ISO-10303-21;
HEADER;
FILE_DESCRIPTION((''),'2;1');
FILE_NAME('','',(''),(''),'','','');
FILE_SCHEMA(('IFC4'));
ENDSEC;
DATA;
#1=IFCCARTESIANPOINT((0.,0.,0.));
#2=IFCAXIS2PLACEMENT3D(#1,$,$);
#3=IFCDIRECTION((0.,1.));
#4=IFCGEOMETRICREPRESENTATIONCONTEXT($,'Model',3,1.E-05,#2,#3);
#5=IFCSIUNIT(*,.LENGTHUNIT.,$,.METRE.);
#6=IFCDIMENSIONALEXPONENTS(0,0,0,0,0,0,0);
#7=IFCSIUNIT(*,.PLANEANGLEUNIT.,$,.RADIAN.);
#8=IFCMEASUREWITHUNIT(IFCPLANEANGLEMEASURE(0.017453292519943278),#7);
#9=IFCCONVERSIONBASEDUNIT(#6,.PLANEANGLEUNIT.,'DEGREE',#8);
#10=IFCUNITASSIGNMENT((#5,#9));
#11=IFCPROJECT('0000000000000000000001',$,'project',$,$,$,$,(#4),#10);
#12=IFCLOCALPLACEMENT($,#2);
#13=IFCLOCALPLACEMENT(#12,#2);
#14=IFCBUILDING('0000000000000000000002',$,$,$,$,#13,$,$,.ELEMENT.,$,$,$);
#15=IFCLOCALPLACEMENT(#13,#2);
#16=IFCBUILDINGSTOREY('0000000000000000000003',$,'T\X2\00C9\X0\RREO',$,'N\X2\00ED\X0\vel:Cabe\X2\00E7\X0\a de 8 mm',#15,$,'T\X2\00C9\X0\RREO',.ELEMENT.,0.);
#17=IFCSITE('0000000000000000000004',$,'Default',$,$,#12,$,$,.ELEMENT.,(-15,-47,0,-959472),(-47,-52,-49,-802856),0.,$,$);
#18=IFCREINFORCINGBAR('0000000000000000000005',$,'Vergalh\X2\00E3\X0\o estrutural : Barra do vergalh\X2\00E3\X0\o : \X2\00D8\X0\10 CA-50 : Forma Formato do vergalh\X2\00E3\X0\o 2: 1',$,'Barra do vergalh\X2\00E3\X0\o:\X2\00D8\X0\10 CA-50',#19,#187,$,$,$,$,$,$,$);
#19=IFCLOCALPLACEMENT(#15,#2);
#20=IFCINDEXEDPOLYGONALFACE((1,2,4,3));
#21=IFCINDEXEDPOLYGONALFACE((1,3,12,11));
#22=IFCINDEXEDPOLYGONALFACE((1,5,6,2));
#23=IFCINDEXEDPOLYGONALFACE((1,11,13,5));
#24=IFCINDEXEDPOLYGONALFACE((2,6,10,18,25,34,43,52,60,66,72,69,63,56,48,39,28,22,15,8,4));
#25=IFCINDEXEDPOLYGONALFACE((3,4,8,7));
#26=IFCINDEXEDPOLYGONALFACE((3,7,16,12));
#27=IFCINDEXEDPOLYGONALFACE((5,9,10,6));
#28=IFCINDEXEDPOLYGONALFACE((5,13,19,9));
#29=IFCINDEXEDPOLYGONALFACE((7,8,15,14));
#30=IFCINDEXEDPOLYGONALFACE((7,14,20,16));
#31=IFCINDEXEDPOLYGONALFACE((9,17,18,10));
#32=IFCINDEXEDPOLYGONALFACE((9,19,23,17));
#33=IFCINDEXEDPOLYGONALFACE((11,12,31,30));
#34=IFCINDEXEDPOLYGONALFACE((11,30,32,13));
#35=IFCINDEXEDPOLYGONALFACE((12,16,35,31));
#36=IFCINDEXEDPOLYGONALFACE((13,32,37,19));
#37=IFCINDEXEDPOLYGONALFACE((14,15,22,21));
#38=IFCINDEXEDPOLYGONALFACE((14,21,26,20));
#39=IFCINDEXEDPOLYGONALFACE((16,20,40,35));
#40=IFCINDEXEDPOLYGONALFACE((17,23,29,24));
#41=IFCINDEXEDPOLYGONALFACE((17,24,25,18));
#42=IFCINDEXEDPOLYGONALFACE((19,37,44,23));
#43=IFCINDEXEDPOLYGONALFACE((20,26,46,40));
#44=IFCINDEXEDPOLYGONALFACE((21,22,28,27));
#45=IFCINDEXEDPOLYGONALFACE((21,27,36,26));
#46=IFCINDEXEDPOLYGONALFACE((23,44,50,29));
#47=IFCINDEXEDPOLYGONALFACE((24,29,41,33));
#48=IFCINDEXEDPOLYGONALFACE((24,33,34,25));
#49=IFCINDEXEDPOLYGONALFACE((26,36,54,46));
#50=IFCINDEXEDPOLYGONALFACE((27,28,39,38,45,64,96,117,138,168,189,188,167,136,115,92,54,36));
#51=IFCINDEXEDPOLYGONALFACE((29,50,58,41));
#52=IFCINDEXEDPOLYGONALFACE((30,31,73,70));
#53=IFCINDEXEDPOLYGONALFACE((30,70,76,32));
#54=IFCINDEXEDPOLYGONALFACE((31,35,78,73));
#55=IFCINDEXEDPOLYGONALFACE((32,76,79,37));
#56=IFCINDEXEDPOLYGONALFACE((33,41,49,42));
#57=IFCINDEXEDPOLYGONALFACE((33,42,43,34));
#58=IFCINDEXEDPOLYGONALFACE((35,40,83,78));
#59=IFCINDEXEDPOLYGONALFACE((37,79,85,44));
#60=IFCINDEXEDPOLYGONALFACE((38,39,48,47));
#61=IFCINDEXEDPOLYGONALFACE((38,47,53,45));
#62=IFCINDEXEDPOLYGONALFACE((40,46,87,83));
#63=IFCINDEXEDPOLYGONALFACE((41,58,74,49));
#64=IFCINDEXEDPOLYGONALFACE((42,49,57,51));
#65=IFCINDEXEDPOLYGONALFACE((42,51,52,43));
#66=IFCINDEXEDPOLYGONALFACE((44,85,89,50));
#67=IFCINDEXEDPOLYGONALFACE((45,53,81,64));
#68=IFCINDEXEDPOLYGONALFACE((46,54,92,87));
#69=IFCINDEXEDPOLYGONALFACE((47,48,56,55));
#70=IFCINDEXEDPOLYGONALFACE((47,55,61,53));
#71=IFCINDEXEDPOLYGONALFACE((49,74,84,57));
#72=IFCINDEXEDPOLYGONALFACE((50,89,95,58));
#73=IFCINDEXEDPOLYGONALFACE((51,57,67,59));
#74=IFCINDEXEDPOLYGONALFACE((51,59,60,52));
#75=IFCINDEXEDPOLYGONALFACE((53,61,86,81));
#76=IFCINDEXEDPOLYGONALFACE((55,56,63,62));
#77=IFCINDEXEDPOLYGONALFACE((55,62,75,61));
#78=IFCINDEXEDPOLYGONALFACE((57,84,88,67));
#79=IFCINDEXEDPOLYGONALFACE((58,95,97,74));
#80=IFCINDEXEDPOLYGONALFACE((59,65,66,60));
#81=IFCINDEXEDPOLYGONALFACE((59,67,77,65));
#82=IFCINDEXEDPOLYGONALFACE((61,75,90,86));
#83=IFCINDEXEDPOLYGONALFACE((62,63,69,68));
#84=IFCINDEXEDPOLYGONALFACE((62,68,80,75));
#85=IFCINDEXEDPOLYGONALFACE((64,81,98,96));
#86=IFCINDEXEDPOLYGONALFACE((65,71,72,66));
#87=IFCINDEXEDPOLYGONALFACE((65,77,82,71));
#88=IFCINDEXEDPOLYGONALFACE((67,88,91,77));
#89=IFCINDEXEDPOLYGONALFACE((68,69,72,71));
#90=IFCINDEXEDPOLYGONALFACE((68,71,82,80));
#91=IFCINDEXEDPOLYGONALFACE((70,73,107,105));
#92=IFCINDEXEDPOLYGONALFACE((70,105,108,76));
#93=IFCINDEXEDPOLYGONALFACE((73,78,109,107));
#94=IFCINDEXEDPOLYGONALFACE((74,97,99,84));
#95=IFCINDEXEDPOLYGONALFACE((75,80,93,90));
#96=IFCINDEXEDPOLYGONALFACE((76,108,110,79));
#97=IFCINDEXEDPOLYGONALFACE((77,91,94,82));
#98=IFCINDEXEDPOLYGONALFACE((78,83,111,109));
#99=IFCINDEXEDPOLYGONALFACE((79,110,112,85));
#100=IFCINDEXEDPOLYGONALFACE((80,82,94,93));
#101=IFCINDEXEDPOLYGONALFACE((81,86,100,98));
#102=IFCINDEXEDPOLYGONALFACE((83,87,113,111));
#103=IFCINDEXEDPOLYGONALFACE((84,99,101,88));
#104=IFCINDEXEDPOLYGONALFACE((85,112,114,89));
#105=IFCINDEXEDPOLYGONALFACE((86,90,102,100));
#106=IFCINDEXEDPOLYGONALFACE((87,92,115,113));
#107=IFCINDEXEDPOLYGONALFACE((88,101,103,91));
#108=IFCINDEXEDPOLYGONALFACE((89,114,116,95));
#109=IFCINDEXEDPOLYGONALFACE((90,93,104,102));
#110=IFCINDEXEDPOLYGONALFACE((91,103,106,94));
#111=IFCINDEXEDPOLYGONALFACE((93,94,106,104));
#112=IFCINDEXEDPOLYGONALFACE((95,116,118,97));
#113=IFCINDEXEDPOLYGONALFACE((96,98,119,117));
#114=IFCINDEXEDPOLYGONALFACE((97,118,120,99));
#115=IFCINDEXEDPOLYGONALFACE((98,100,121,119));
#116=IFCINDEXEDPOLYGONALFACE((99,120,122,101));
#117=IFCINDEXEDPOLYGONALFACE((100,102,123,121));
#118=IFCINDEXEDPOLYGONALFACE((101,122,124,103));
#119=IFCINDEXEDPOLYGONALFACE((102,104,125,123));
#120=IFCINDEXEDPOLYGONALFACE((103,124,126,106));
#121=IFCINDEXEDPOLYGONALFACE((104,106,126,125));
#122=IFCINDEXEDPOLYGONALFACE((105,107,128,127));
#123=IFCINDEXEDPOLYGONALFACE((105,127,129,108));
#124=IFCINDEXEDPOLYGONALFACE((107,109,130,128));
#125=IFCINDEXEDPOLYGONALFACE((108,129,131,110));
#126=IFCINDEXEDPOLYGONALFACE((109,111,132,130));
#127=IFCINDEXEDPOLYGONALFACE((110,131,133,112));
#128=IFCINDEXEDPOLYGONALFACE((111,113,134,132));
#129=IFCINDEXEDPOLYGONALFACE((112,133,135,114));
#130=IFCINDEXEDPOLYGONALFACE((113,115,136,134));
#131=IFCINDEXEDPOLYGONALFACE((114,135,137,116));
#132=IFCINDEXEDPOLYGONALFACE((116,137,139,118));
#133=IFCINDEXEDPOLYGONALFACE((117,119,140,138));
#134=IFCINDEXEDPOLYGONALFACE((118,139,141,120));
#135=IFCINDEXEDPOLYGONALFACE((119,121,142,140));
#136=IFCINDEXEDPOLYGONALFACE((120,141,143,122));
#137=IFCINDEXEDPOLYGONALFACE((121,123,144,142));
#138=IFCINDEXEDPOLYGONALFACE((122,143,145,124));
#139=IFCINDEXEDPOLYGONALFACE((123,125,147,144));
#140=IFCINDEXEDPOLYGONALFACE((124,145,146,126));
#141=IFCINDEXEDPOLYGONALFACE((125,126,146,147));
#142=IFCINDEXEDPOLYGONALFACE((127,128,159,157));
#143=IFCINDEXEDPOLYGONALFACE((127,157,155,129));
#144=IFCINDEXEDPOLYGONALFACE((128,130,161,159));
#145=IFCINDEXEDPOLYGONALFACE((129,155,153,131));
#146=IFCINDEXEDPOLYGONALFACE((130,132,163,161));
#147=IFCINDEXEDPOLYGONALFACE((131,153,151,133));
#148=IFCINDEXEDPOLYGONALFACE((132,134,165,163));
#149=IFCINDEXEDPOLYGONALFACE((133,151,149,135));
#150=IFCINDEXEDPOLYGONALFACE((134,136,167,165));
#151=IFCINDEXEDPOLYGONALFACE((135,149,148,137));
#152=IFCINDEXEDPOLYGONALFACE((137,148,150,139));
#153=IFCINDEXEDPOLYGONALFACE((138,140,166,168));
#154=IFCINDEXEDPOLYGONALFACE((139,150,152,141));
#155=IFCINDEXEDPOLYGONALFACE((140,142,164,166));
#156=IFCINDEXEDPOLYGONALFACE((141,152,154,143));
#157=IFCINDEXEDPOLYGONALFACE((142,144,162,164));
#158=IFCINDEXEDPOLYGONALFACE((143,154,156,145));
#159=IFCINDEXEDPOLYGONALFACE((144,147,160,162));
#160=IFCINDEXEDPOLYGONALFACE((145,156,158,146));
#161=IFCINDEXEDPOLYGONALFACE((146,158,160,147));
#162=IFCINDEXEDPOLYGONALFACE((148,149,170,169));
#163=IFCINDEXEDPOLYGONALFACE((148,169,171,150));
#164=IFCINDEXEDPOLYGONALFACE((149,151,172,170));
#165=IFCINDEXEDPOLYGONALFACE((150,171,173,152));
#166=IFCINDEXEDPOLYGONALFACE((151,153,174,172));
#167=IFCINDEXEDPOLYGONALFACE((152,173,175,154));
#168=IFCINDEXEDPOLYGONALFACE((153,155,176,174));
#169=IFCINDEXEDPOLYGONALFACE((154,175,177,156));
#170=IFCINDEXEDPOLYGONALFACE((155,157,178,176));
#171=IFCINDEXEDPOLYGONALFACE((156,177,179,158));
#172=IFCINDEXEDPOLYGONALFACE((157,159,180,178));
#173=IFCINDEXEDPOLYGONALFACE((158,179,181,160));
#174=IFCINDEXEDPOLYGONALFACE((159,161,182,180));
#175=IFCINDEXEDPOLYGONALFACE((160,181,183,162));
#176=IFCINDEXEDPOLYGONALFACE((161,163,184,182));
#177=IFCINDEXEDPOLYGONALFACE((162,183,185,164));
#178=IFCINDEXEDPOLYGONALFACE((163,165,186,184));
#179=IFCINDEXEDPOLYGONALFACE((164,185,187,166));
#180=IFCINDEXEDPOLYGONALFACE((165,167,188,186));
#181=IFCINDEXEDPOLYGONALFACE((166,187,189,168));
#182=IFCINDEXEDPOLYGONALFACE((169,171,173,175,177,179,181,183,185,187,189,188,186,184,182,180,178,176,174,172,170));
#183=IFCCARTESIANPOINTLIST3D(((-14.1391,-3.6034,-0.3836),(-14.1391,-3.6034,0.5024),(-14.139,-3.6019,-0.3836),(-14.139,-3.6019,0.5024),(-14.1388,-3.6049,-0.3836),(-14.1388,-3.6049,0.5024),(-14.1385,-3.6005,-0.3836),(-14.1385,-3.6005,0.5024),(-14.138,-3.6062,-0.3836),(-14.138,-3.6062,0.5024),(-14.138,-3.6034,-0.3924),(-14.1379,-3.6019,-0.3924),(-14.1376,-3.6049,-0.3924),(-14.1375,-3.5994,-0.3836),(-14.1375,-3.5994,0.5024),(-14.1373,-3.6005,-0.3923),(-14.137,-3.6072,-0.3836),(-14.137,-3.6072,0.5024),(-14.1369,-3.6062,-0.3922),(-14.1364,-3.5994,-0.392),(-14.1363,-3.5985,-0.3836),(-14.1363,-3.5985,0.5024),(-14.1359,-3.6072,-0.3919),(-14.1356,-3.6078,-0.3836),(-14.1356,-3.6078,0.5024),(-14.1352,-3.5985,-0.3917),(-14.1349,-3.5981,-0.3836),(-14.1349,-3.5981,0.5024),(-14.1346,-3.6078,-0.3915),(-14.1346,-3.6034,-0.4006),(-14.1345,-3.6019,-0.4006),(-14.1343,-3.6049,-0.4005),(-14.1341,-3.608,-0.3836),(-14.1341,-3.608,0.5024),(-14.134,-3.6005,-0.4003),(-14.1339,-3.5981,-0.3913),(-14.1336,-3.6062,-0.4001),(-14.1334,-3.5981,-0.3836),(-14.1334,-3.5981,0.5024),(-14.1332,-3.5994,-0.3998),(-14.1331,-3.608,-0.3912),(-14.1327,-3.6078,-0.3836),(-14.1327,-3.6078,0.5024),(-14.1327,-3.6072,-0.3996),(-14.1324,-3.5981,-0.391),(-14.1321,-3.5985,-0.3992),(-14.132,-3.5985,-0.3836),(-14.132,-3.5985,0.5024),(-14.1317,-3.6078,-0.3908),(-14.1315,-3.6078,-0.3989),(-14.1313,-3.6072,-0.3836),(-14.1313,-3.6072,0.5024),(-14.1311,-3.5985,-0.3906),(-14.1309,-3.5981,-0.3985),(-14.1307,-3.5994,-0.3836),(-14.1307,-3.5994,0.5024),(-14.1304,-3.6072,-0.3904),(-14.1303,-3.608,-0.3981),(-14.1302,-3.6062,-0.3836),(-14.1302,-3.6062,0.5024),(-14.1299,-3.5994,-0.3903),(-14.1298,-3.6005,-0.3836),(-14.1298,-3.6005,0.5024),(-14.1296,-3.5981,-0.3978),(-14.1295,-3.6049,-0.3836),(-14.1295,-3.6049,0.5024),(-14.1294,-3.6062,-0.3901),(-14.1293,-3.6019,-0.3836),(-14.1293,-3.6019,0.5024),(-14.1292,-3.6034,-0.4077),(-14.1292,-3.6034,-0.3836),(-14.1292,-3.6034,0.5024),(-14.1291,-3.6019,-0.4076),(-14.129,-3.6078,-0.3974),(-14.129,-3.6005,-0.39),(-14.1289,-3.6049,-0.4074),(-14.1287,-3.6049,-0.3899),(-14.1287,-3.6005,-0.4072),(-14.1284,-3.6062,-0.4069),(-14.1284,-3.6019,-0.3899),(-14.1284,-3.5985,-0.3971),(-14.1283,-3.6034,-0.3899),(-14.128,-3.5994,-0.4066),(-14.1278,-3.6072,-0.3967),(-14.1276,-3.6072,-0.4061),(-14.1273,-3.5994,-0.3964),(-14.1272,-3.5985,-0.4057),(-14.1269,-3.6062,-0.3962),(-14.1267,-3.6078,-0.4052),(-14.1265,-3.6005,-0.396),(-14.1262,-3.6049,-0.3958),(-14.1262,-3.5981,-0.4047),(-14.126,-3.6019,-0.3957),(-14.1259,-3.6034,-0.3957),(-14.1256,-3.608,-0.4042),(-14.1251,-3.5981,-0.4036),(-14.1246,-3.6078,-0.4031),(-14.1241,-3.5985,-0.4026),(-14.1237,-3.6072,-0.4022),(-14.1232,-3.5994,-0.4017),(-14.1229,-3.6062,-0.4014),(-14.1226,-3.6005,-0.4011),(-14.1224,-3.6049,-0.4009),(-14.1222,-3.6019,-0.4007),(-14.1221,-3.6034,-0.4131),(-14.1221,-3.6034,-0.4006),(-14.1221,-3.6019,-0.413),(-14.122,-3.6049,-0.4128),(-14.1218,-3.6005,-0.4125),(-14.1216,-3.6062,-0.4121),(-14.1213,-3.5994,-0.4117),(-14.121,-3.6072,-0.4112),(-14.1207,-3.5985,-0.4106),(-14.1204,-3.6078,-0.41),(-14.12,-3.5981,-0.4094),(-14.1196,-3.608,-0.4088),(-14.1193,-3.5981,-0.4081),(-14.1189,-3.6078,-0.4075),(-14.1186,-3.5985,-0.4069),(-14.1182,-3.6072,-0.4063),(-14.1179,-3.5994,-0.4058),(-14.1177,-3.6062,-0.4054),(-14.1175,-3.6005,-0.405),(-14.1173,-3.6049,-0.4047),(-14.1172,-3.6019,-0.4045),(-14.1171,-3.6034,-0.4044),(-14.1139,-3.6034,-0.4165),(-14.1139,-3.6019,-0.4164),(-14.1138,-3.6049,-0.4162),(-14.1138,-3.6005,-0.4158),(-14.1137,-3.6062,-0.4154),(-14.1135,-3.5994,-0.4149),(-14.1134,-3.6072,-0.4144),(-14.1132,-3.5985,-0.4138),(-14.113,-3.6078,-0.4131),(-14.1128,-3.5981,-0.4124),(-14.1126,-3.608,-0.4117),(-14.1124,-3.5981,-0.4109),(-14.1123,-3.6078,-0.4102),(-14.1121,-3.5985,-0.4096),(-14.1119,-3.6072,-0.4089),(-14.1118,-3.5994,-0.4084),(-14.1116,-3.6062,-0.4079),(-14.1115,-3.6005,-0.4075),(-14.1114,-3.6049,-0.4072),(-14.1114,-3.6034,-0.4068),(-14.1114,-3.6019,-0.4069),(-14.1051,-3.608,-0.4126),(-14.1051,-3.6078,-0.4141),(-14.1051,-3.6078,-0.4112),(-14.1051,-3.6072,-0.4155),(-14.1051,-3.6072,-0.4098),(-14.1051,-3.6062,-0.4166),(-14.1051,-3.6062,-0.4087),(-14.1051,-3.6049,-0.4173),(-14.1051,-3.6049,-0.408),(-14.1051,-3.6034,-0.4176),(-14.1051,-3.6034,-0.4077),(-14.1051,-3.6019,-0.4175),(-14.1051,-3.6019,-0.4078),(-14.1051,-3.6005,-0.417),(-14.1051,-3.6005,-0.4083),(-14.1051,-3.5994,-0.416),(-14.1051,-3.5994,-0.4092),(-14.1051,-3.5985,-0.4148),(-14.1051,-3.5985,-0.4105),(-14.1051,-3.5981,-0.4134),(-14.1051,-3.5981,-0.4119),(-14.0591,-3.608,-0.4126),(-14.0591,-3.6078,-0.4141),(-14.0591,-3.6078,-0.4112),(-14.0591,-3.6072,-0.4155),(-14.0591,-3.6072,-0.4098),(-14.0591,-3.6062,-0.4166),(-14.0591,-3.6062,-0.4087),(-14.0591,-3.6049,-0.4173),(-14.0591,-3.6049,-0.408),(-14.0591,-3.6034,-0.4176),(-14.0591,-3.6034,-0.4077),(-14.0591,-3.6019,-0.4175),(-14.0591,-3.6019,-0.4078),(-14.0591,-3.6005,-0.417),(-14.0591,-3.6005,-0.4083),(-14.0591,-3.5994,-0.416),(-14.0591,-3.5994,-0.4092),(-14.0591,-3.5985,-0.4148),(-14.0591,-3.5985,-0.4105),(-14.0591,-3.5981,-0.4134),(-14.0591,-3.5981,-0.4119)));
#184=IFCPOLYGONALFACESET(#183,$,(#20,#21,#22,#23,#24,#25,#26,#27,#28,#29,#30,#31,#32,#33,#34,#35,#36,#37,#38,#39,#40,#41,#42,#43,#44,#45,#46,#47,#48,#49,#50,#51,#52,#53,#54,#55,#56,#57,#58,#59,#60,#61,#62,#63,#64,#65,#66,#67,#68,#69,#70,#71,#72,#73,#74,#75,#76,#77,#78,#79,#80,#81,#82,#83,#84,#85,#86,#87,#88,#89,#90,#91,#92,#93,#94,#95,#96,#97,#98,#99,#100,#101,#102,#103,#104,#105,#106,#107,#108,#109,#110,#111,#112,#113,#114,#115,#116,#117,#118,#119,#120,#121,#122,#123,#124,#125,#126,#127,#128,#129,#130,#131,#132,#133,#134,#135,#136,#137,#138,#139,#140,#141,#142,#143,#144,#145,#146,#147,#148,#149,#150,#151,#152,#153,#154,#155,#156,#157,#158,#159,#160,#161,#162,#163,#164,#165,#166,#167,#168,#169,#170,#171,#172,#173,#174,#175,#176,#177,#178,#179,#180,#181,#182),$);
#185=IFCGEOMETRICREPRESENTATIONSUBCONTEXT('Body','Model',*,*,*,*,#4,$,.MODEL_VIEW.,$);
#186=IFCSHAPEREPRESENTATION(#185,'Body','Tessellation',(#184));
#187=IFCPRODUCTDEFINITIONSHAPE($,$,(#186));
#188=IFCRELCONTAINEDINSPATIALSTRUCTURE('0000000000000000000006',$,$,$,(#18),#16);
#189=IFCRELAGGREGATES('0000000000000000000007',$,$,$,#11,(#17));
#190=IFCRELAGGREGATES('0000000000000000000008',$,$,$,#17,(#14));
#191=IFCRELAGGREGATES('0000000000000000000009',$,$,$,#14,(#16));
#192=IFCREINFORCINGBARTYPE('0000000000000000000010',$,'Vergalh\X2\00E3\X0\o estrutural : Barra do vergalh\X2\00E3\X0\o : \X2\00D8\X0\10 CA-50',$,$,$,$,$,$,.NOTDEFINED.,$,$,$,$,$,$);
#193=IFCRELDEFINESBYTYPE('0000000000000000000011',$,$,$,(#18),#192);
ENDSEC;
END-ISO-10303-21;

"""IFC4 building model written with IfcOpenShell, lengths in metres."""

from ifc_helpers import new_model, entity, si_unit, converted_unit, direction, origin, place, context, subcontext, project, spatial, type_object, element, save


model = new_model("IFC4")

# Units and contexts
model_context = context("Model", 3, precision=1e-05, world=origin(), true_north=direction((0.0, 1.0)))
body_context = subcontext(model_context, "Body", "Model", "MODEL_VIEW")
ifc_project = project(units=[si_unit("LENGTHUNIT", "METRE"), converted_unit("PLANEANGLEUNIT", "DEGREE", entity("IfcPlaneAngleMeasure", 0.017453292519943278), si_unit("PLANEANGLEUNIT", "RADIAN"), dimensions=[0, 0, 0, 0, 0, 0, 0])], contexts=[model_context])

# Site, building, storey
site_placement = place(None, origin())
site = spatial("IfcSite", under=ifc_project, at=site_placement, Name="Default", CompositionType="ELEMENT", RefLatitude=(-15, -47, 0, -959472), RefLongitude=(-47, -52, -49, -802856), RefElevation=0.0)
building_placement = place(site_placement, origin())
building = spatial("IfcBuilding", under=site, at=building_placement, CompositionType="ELEMENT")
storey_placement = place(building_placement, origin())
storey = spatial("IfcBuildingStorey", under=building, at=storey_placement, Name="TÉRREO", ObjectType="Nível:Cabeça de 8 mm", LongName="TÉRREO", CompositionType="ELEMENT", Elevation=0.0)

# Reinforcing bar
reinforcing_bar_type_1 = type_object("IfcReinforcingBarType", Name="Vergalhão estrutural : Barra do vergalhão : Ø10 CA-50", PredefinedType="NOTDEFINED")
reinforcing_bar_1_placement = place(storey_placement, origin())
element("IfcReinforcingBar", 1, at=reinforcing_bar_1_placement, inside=storey, type_object=reinforcing_bar_type_1, Name="Vergalhão estrutural : Barra do vergalhão : Ø10 CA-50 : Forma Formato do vergalhão 2: 1", ObjectType="Barra do vergalhão:Ø10 CA-50", context=body_context, shape_type="AdvancedSweptSolid", body=[
    entity("IfcSweptDiskSolid", entity("IfcIndexedPolyCurve", entity("IfcCartesianPointList3D", [[-14.0591, -3.603, -0.4126], [-14.1051, -3.603, -0.4126], [-14.1256, -3.603, -0.4042], [-14.1341, -3.603, -0.3836], [-14.1341, -3.603, 0.5024]]), [entity("IfcLineIndex", [1, 2]), entity("IfcArcIndex", [2, 3, 4]), entity("IfcLineIndex", [4, 5])], False), 0.005, None, 0.0, 92.0),
])

save(model, "model.ifc")
